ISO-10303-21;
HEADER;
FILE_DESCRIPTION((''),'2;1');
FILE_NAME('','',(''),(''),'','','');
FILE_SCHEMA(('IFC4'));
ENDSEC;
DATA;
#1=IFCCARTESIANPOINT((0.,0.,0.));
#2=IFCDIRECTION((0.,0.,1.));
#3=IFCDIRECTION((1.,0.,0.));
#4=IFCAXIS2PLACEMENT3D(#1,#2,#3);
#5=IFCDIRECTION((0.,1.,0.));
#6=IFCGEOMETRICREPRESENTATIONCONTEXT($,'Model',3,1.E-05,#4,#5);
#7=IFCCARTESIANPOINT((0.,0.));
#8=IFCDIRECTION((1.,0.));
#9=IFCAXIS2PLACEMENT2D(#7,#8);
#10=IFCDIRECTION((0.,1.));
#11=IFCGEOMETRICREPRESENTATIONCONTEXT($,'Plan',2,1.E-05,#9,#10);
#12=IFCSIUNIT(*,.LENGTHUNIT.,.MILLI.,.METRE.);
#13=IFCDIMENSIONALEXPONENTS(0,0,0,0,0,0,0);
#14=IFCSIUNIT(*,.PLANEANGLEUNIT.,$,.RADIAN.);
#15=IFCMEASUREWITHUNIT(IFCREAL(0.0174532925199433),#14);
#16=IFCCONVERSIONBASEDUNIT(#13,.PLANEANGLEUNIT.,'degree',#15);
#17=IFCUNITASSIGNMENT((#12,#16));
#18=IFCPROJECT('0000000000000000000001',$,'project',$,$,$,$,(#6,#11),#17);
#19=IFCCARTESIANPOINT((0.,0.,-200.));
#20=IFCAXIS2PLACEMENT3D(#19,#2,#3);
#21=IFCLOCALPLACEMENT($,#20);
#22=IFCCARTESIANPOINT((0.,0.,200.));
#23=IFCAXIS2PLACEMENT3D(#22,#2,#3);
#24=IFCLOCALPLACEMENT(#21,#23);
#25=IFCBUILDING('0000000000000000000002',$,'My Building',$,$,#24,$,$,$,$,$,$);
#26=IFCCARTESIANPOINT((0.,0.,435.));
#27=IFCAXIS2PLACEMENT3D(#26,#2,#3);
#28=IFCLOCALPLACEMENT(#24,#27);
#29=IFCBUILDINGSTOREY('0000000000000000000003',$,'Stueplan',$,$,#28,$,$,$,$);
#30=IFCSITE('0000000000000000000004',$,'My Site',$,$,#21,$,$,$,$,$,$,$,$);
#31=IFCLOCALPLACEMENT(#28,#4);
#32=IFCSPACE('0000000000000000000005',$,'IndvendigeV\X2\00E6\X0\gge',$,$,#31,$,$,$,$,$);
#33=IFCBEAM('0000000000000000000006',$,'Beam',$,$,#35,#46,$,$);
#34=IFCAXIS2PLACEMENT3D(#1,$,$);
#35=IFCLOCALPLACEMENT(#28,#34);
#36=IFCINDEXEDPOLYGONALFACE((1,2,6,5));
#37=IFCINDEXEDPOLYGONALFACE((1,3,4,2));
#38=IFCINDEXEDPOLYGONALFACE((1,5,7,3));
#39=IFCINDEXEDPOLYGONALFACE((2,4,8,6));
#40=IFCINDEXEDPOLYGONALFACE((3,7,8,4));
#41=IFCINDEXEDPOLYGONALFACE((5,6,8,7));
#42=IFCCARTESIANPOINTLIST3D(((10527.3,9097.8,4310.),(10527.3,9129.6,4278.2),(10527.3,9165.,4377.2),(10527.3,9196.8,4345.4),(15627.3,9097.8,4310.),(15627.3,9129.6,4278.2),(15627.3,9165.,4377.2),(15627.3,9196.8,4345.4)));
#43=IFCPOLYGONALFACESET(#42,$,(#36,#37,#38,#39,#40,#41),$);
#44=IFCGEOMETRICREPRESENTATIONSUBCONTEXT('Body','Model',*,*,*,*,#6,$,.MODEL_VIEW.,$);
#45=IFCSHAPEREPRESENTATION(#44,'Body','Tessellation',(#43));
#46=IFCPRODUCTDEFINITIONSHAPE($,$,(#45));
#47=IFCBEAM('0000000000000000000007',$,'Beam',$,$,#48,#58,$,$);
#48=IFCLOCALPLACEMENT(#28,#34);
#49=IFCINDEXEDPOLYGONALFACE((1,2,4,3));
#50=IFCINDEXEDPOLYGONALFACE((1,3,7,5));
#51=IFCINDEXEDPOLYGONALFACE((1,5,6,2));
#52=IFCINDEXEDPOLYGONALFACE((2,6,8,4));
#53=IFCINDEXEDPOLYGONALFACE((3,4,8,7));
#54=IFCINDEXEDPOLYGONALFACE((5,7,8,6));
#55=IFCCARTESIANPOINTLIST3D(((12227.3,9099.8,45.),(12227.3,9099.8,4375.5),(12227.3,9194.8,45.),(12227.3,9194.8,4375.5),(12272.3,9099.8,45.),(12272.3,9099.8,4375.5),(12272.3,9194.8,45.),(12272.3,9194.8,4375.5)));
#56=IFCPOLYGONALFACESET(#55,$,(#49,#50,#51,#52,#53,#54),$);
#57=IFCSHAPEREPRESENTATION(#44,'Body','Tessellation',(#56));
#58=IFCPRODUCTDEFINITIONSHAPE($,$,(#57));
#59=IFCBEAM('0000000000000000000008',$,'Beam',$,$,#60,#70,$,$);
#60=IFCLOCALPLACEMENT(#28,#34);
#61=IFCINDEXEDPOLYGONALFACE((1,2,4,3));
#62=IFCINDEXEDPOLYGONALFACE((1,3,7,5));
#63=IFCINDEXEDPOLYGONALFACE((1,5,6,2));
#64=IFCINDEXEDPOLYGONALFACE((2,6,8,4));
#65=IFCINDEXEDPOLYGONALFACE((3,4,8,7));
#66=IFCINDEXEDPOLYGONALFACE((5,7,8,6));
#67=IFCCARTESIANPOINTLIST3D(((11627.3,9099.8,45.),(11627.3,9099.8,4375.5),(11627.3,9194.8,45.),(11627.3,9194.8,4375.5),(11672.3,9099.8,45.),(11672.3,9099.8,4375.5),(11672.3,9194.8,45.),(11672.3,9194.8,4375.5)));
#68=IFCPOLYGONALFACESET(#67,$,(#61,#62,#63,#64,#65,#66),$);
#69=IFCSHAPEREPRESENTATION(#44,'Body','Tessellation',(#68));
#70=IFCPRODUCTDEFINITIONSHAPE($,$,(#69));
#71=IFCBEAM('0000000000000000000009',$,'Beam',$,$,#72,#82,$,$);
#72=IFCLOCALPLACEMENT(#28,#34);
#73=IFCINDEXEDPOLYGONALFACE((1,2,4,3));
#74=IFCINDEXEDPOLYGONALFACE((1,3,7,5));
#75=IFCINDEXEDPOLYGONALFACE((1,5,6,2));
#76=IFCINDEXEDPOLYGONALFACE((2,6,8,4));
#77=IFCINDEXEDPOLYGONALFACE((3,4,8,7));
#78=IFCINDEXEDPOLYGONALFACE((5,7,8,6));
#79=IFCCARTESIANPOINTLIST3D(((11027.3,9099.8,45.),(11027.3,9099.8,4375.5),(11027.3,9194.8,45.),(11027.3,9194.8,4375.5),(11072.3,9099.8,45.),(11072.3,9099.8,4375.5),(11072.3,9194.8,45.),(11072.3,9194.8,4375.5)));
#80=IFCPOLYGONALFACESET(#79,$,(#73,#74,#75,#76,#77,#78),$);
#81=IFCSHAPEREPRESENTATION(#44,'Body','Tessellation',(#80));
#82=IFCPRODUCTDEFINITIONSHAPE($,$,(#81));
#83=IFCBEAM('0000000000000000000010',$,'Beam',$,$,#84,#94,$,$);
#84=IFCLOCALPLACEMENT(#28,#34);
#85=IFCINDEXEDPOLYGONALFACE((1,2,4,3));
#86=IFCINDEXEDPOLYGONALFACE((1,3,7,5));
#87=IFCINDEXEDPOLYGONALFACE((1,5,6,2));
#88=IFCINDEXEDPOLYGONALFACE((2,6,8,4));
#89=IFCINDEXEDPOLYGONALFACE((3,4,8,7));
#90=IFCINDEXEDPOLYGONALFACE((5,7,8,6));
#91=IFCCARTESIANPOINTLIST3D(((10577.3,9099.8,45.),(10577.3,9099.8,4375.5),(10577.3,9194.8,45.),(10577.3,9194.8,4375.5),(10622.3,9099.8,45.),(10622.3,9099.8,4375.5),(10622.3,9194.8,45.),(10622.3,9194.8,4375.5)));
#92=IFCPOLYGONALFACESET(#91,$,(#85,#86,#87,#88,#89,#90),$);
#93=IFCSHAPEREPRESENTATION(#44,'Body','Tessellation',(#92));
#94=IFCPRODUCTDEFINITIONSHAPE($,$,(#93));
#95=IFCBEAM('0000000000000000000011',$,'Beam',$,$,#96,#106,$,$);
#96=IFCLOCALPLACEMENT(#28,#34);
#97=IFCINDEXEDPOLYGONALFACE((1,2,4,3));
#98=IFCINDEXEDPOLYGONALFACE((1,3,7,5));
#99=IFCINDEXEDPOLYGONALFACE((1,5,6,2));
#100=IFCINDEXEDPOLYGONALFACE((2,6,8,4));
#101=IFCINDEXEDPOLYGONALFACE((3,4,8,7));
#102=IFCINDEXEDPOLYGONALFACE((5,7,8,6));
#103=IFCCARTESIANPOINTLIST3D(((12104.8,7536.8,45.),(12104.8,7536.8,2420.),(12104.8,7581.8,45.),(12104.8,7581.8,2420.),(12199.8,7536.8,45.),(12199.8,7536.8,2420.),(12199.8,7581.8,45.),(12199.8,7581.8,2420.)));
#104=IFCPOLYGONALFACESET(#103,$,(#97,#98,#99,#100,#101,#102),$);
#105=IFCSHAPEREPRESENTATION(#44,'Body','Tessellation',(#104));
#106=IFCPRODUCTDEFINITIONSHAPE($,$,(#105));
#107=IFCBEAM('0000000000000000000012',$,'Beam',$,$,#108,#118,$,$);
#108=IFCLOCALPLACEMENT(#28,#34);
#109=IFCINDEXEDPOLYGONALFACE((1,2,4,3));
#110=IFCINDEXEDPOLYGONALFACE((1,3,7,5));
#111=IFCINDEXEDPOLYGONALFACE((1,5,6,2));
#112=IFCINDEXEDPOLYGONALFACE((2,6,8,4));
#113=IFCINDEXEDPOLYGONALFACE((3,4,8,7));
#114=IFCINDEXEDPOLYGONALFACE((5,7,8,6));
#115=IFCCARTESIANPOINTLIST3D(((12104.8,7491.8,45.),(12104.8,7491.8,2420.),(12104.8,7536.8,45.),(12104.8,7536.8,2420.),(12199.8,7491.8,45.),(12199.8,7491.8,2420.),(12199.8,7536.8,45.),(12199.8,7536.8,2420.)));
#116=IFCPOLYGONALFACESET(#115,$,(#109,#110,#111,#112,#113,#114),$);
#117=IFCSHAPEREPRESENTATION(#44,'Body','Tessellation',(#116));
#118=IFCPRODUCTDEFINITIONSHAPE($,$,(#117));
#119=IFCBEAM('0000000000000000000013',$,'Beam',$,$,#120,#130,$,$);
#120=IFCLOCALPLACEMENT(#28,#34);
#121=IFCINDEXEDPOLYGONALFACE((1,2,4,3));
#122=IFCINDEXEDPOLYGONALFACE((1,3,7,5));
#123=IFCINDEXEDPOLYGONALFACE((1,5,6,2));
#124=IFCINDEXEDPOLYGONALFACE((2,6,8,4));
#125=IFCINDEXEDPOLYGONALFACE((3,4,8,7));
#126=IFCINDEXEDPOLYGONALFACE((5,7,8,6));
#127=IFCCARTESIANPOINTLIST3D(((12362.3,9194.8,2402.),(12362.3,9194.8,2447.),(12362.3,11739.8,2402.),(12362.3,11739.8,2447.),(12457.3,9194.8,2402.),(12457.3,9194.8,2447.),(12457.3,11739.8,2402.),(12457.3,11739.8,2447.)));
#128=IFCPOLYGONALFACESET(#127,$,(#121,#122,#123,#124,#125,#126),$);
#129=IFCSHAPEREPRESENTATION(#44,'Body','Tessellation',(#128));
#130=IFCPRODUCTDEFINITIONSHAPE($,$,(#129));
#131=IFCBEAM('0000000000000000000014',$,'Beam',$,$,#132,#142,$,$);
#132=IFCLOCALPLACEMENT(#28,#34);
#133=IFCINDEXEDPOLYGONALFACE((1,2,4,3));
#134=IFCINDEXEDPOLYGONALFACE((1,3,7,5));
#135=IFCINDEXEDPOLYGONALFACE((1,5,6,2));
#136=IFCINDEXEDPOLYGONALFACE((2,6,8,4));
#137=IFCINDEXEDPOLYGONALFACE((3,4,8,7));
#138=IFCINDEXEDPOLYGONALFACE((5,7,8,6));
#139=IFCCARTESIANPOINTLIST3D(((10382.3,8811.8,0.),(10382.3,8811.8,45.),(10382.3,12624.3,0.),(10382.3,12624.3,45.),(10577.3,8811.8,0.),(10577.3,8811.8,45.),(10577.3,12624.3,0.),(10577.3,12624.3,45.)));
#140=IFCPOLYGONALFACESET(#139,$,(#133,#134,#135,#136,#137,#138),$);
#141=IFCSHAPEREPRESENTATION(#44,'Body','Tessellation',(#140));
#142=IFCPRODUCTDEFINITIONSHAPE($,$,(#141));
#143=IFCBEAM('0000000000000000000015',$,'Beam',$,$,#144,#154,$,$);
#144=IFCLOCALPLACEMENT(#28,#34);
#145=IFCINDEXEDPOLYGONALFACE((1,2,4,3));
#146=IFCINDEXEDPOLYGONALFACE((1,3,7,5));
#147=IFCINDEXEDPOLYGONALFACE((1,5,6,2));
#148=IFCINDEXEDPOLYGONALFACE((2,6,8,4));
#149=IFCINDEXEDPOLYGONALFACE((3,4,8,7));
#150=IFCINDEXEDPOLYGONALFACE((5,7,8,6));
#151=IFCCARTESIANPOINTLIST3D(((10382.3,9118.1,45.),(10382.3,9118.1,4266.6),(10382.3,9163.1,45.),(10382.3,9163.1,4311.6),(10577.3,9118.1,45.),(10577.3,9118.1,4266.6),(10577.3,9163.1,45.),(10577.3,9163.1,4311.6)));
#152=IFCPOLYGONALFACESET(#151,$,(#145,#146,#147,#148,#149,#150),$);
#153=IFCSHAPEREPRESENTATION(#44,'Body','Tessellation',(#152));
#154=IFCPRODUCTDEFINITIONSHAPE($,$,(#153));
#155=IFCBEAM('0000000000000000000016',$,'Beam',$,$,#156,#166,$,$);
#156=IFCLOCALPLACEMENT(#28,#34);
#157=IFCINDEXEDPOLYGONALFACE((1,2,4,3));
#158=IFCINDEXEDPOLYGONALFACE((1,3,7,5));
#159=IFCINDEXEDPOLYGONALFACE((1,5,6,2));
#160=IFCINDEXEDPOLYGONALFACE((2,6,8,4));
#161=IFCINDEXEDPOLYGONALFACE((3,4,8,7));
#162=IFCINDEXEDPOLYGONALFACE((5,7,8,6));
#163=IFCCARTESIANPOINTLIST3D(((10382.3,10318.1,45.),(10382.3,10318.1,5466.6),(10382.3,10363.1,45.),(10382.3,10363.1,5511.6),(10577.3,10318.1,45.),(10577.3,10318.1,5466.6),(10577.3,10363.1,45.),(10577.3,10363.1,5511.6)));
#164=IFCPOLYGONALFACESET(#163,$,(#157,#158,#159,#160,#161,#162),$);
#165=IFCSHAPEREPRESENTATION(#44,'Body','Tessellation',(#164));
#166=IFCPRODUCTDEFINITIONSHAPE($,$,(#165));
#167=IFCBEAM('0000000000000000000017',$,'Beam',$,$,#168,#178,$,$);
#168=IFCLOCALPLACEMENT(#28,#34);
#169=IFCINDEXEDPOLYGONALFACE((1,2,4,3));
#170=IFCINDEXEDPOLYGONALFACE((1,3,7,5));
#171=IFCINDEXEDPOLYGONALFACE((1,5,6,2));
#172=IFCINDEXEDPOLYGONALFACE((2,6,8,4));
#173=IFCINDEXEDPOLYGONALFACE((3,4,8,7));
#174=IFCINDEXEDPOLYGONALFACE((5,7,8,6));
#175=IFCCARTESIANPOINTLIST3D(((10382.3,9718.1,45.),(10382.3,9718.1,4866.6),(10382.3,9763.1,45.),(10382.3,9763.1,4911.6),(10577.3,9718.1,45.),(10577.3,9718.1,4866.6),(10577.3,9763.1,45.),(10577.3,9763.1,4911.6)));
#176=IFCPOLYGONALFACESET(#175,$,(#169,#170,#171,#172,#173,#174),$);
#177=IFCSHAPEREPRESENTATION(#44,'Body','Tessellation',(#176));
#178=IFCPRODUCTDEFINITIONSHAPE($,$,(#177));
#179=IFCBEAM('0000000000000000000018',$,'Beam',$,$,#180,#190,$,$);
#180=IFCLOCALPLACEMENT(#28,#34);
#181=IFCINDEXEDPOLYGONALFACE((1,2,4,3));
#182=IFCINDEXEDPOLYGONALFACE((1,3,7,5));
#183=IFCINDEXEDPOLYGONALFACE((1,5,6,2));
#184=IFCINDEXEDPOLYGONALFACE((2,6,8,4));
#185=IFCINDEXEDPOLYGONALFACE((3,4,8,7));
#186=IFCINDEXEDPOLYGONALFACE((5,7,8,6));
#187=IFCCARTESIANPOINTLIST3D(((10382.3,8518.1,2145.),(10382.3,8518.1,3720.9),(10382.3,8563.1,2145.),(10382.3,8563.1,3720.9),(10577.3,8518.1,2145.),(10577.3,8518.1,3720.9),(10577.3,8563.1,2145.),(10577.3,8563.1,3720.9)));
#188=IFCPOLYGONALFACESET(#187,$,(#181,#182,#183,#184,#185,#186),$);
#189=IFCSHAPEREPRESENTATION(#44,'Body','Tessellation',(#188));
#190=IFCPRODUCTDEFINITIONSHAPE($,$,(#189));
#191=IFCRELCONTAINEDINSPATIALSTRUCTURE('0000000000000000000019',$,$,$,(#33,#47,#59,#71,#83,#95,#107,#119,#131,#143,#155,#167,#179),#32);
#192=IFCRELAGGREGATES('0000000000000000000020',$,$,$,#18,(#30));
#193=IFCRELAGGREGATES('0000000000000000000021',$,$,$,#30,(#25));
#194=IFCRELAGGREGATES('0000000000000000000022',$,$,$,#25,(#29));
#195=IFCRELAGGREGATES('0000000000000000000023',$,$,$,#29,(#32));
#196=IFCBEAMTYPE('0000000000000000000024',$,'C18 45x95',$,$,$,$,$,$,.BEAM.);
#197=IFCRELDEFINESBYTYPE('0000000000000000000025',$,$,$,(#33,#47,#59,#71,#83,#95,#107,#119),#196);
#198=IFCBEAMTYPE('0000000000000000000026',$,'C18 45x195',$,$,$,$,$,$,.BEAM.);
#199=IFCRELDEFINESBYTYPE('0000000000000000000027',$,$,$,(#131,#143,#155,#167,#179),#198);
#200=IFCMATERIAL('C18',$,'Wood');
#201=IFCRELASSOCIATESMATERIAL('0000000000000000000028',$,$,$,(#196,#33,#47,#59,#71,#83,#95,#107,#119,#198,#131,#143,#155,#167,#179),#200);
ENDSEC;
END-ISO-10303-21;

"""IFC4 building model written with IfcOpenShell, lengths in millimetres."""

from ifc_helpers import new_model, entity, si_unit, converted_unit, direction, frame, origin_with_axes, origin_2d_with_axis, place, context, subcontext, project, spatial, rectangle, extrude, clip, halfspace, material, material_profile, profile_set, profile_usage, type_object, element, save


model = new_model("IFC4")

# Units and contexts
model_context = context("Model", 3, precision=1e-05, world=origin_with_axes(), true_north=direction((0.0, 1.0, 0.0)))
plan_context = context("Plan", 2, precision=1e-05, world=origin_2d_with_axis(), true_north=direction((0.0, 1.0)))
body_context_1 = subcontext(model_context, "Body", "Model", "MODEL_VIEW")
ifc_project = project(units=[si_unit("LENGTHUNIT", "METRE", prefix="MILLI"), converted_unit("PLANEANGLEUNIT", "degree", entity("IfcReal", 0.0174532925199433), si_unit("PLANEANGLEUNIT", "RADIAN"), dimensions=[0, 0, 0, 0, 0, 0, 0])], contexts=[model_context, plan_context])

# Site, building, storey
site_placement = place(None, frame((0.0, 0.0, -200.0), z_axis=(0.0, 0.0, 1.0), x_axis=(1.0, 0.0, 0.0)))
site = spatial("IfcSite", under=ifc_project, at=site_placement, Name="My Site")
building_placement = place(site_placement, frame((0.0, 0.0, 200.0), z_axis=(0.0, 0.0, 1.0), x_axis=(1.0, 0.0, 0.0)))
building = spatial("IfcBuilding", under=site, at=building_placement, Name="My Building")
storey_placement = place(building_placement, frame((0.0, 0.0, 435.0), z_axis=(0.0, 0.0, 1.0), x_axis=(1.0, 0.0, 0.0)))
storey = spatial("IfcBuildingStorey", under=building, at=storey_placement, Name="Stueplan")

# Shared definitions
ifc_material = material(Name="C18", Category="Wood")

# Shared definitions
space_1_placement = place(storey_placement, frame((0.0, 0.0, 0.0), z_axis=(0.0, 0.0, 1.0), x_axis=(1.0, 0.0, 0.0)))
space_1 = spatial("IfcSpace", under=storey, at=space_1_placement, Name="IndvendigeVægge")

# Beams
ifc_material_profile_1 = material_profile(ifc_material, rectangle(XDim=45.0, YDim=95.0))
ifc_profile_set_1 = profile_set([ifc_material_profile_1], Name="woodStructural")
beam_type_1 = type_object("IfcBeamType", Name="C18 45x95", PredefinedType="BEAM", material=ifc_profile_set_1)
ifc_profile_usage_1 = profile_usage(ifc_profile_set_1, cardinal=5)
beam_1_placement = place(space_1_placement, frame((10527.3, 9147.3, 4327.7), z_axis=(1.0, 0.0, 0.0), x_axis=(0.0, -0.707107, 0.707107)))
element("IfcBeam", 1, at=beam_1_placement, inside=space_1, type_object=beam_type_1, material=ifc_profile_usage_1, Name="Beam", context=body_context_1, shape_type="SweptSolid", body=[
    extrude(rectangle(XDim=45.0, YDim=95.0), origin_with_axes(), (0.0, 0.0, 1.0), 5100.0),
])
ifc_profile_usage_2 = profile_usage(ifc_profile_set_1)
beam_2_placement = place(space_1_placement, frame((12249.8, 9147.3, 45.0), z_axis=(0.0, 0.0, 1.0), x_axis=(-1.0, 0.0, 0.0)))
element("IfcBeam", 2, at=beam_2_placement, inside=space_1, type_object=beam_type_1, material=ifc_profile_usage_2, Name="Beam", context=body_context_1, shape_type="SweptSolid", body=[
    extrude(rectangle(XDim=45.0, YDim=95.0), origin_with_axes(), (0.0, 0.0, 1.0), 4330.5),
])
ifc_profile_usage_3 = profile_usage(ifc_profile_set_1)
beam_3_placement = place(space_1_placement, frame((11649.8, 9147.3, 45.0), z_axis=(0.0, 0.0, 1.0), x_axis=(-1.0, 0.0, 0.0)))
element("IfcBeam", 3, at=beam_3_placement, inside=space_1, type_object=beam_type_1, material=ifc_profile_usage_3, Name="Beam", context=body_context_1, shape_type="SweptSolid", body=[
    extrude(rectangle(XDim=45.0, YDim=95.0), origin_with_axes(), (0.0, 0.0, 1.0), 4330.5),
])
ifc_profile_usage_4 = profile_usage(ifc_profile_set_1)
beam_4_placement = place(space_1_placement, frame((11049.8, 9147.3, 45.0), z_axis=(0.0, 0.0, 1.0), x_axis=(-1.0, 0.0, 0.0)))
element("IfcBeam", 4, at=beam_4_placement, inside=space_1, type_object=beam_type_1, material=ifc_profile_usage_4, Name="Beam", context=body_context_1, shape_type="SweptSolid", body=[
    extrude(rectangle(XDim=45.0, YDim=95.0), origin_with_axes(), (0.0, 0.0, 1.0), 4330.5),
])
ifc_profile_usage_5 = profile_usage(ifc_profile_set_1)
beam_5_placement = place(space_1_placement, frame((10599.8, 9147.3, 45.0), z_axis=(0.0, 0.0, 1.0), x_axis=(-1.0, 0.0, 0.0)))
element("IfcBeam", 5, at=beam_5_placement, inside=space_1, type_object=beam_type_1, material=ifc_profile_usage_5, Name="Beam", context=body_context_1, shape_type="SweptSolid", body=[
    extrude(rectangle(XDim=45.0, YDim=95.0), origin_with_axes(), (0.0, 0.0, 1.0), 4330.5),
])
ifc_profile_usage_6 = profile_usage(ifc_profile_set_1)
beam_6_placement = place(space_1_placement, frame((12152.3, 7559.3, 45.0), z_axis=(0.0, 0.0, 1.0), x_axis=(0.0, 1.0, 0.0)))
element("IfcBeam", 6, at=beam_6_placement, inside=space_1, type_object=beam_type_1, material=ifc_profile_usage_6, Name="Beam", context=body_context_1, shape_type="SweptSolid", body=[
    extrude(rectangle(XDim=45.0, YDim=95.0), origin_with_axes(), (0.0, 0.0, 1.0), 2375.0),
])
ifc_profile_usage_7 = profile_usage(ifc_profile_set_1)
beam_7_placement = place(space_1_placement, frame((12152.3, 7514.3, 45.0), z_axis=(0.0, 0.0, 1.0), x_axis=(0.0, 1.0, 0.0)))
element("IfcBeam", 7, at=beam_7_placement, inside=space_1, type_object=beam_type_1, material=ifc_profile_usage_7, Name="Beam", context=body_context_1, shape_type="SweptSolid", body=[
    extrude(rectangle(XDim=45.0, YDim=95.0), origin_with_axes(), (0.0, 0.0, 1.0), 2375.0),
])
ifc_profile_usage_8 = profile_usage(ifc_profile_set_1, cardinal=5)
beam_8_placement = place(space_1_placement, frame((12409.8, 9194.8, 2424.5), z_axis=(0.0, 1.0, 0.0), x_axis=(0.0, 0.0, 1.0)))
element("IfcBeam", 8, at=beam_8_placement, inside=space_1, type_object=beam_type_1, material=ifc_profile_usage_8, Name="Beam", context=body_context_1, shape_type="SweptSolid", body=[
    extrude(rectangle(XDim=45.0, YDim=95.0), origin_with_axes(), (0.0, 0.0, 1.0), 2545.0),
])
ifc_material_profile_2 = material_profile(ifc_material, rectangle(XDim=45.0, YDim=195.0))
ifc_profile_set_2 = profile_set([ifc_material_profile_2], Name="woodStructural")
ifc_profile_usage_9 = profile_usage(ifc_profile_set_2)
beam_type_2 = type_object("IfcBeamType", Name="C18 45x195", PredefinedType="BEAM", material=ifc_profile_set_2)
beam_9_placement = place(space_1_placement, frame((10479.8, 8811.8, 22.5), z_axis=(0.0, 1.0, 0.0), x_axis=(0.0, 0.0, 1.0)))
element("IfcBeam", 9, at=beam_9_placement, inside=space_1, type_object=beam_type_2, material=ifc_profile_usage_9, Name="Beam", context=body_context_1, shape_type="SweptSolid", body=[
    extrude(rectangle(XDim=45.0, YDim=195.0), origin_with_axes(), (0.0, 0.0, 1.0), 3812.5),
])
ifc_profile_usage_10 = profile_usage(ifc_profile_set_2)
beam_10_placement = place(space_1_placement, frame((10479.8, 9140.6, 45.0), z_axis=(0.0, 0.0, 1.0), x_axis=(0.0, 1.0, 0.0)))
element("IfcBeam", 10, at=beam_10_placement, inside=space_1, type_object=beam_type_2, material=ifc_profile_usage_10, Name="Beam", context=body_context_1, shape_type="Clipping", body=[
    clip(extrude(rectangle(XDim=45.0, YDim=195.0), origin_with_axes(), (0.0, 0.0, 1.0), 4439.1), halfspace(frame((-1635.7, 0.0, 2608.4), z_axis=(-0.707107, 0.0, 0.707107), x_axis=(0.0, 1.0, 0.0)), False)),
])
ifc_profile_usage_11 = profile_usage(ifc_profile_set_2)
beam_11_placement = place(space_1_placement, frame((10479.8, 10340.6, 45.0), z_axis=(0.0, 0.0, 1.0), x_axis=(0.0, 1.0, 0.0)))
element("IfcBeam", 11, at=beam_11_placement, inside=space_1, type_object=beam_type_2, material=ifc_profile_usage_11, Name="Beam", context=body_context_1, shape_type="Clipping", body=[
    clip(extrude(rectangle(XDim=45.0, YDim=195.0), origin_with_axes(), (0.0, 0.0, 1.0), 5639.1), halfspace(frame((-2835.7, 0.0, 2608.4), z_axis=(-0.707107, 0.0, 0.707107), x_axis=(0.0, 1.0, 0.0)), False)),
])
ifc_profile_usage_12 = profile_usage(ifc_profile_set_2)
beam_12_placement = place(space_1_placement, frame((10479.8, 9740.6, 45.0), z_axis=(0.0, 0.0, 1.0), x_axis=(0.0, 1.0, 0.0)))
element("IfcBeam", 12, at=beam_12_placement, inside=space_1, type_object=beam_type_2, material=ifc_profile_usage_12, Name="Beam", context=body_context_1, shape_type="Clipping", body=[
    clip(extrude(rectangle(XDim=45.0, YDim=195.0), origin_with_axes(), (0.0, 0.0, 1.0), 5039.1), halfspace(frame((-2235.7, 0.0, 2608.4), z_axis=(-0.707107, 0.0, 0.707107), x_axis=(0.0, 1.0, 0.0)), False)),
])
ifc_profile_usage_13 = profile_usage(ifc_profile_set_2)
beam_13_placement = place(space_1_placement, frame((10479.8, 8540.6, 2145.0), z_axis=(0.0, 0.0, 1.0), x_axis=(0.0, 1.0, 0.0)))
element("IfcBeam", 13, at=beam_13_placement, inside=space_1, type_object=beam_type_2, material=ifc_profile_usage_13, Name="Beam", context=body_context_1, shape_type="SweptSolid", body=[
    extrude(rectangle(XDim=45.0, YDim=195.0), origin_with_axes(), (0.0, 0.0, 1.0), 1575.9),
])

save(model, "model.ifc")
